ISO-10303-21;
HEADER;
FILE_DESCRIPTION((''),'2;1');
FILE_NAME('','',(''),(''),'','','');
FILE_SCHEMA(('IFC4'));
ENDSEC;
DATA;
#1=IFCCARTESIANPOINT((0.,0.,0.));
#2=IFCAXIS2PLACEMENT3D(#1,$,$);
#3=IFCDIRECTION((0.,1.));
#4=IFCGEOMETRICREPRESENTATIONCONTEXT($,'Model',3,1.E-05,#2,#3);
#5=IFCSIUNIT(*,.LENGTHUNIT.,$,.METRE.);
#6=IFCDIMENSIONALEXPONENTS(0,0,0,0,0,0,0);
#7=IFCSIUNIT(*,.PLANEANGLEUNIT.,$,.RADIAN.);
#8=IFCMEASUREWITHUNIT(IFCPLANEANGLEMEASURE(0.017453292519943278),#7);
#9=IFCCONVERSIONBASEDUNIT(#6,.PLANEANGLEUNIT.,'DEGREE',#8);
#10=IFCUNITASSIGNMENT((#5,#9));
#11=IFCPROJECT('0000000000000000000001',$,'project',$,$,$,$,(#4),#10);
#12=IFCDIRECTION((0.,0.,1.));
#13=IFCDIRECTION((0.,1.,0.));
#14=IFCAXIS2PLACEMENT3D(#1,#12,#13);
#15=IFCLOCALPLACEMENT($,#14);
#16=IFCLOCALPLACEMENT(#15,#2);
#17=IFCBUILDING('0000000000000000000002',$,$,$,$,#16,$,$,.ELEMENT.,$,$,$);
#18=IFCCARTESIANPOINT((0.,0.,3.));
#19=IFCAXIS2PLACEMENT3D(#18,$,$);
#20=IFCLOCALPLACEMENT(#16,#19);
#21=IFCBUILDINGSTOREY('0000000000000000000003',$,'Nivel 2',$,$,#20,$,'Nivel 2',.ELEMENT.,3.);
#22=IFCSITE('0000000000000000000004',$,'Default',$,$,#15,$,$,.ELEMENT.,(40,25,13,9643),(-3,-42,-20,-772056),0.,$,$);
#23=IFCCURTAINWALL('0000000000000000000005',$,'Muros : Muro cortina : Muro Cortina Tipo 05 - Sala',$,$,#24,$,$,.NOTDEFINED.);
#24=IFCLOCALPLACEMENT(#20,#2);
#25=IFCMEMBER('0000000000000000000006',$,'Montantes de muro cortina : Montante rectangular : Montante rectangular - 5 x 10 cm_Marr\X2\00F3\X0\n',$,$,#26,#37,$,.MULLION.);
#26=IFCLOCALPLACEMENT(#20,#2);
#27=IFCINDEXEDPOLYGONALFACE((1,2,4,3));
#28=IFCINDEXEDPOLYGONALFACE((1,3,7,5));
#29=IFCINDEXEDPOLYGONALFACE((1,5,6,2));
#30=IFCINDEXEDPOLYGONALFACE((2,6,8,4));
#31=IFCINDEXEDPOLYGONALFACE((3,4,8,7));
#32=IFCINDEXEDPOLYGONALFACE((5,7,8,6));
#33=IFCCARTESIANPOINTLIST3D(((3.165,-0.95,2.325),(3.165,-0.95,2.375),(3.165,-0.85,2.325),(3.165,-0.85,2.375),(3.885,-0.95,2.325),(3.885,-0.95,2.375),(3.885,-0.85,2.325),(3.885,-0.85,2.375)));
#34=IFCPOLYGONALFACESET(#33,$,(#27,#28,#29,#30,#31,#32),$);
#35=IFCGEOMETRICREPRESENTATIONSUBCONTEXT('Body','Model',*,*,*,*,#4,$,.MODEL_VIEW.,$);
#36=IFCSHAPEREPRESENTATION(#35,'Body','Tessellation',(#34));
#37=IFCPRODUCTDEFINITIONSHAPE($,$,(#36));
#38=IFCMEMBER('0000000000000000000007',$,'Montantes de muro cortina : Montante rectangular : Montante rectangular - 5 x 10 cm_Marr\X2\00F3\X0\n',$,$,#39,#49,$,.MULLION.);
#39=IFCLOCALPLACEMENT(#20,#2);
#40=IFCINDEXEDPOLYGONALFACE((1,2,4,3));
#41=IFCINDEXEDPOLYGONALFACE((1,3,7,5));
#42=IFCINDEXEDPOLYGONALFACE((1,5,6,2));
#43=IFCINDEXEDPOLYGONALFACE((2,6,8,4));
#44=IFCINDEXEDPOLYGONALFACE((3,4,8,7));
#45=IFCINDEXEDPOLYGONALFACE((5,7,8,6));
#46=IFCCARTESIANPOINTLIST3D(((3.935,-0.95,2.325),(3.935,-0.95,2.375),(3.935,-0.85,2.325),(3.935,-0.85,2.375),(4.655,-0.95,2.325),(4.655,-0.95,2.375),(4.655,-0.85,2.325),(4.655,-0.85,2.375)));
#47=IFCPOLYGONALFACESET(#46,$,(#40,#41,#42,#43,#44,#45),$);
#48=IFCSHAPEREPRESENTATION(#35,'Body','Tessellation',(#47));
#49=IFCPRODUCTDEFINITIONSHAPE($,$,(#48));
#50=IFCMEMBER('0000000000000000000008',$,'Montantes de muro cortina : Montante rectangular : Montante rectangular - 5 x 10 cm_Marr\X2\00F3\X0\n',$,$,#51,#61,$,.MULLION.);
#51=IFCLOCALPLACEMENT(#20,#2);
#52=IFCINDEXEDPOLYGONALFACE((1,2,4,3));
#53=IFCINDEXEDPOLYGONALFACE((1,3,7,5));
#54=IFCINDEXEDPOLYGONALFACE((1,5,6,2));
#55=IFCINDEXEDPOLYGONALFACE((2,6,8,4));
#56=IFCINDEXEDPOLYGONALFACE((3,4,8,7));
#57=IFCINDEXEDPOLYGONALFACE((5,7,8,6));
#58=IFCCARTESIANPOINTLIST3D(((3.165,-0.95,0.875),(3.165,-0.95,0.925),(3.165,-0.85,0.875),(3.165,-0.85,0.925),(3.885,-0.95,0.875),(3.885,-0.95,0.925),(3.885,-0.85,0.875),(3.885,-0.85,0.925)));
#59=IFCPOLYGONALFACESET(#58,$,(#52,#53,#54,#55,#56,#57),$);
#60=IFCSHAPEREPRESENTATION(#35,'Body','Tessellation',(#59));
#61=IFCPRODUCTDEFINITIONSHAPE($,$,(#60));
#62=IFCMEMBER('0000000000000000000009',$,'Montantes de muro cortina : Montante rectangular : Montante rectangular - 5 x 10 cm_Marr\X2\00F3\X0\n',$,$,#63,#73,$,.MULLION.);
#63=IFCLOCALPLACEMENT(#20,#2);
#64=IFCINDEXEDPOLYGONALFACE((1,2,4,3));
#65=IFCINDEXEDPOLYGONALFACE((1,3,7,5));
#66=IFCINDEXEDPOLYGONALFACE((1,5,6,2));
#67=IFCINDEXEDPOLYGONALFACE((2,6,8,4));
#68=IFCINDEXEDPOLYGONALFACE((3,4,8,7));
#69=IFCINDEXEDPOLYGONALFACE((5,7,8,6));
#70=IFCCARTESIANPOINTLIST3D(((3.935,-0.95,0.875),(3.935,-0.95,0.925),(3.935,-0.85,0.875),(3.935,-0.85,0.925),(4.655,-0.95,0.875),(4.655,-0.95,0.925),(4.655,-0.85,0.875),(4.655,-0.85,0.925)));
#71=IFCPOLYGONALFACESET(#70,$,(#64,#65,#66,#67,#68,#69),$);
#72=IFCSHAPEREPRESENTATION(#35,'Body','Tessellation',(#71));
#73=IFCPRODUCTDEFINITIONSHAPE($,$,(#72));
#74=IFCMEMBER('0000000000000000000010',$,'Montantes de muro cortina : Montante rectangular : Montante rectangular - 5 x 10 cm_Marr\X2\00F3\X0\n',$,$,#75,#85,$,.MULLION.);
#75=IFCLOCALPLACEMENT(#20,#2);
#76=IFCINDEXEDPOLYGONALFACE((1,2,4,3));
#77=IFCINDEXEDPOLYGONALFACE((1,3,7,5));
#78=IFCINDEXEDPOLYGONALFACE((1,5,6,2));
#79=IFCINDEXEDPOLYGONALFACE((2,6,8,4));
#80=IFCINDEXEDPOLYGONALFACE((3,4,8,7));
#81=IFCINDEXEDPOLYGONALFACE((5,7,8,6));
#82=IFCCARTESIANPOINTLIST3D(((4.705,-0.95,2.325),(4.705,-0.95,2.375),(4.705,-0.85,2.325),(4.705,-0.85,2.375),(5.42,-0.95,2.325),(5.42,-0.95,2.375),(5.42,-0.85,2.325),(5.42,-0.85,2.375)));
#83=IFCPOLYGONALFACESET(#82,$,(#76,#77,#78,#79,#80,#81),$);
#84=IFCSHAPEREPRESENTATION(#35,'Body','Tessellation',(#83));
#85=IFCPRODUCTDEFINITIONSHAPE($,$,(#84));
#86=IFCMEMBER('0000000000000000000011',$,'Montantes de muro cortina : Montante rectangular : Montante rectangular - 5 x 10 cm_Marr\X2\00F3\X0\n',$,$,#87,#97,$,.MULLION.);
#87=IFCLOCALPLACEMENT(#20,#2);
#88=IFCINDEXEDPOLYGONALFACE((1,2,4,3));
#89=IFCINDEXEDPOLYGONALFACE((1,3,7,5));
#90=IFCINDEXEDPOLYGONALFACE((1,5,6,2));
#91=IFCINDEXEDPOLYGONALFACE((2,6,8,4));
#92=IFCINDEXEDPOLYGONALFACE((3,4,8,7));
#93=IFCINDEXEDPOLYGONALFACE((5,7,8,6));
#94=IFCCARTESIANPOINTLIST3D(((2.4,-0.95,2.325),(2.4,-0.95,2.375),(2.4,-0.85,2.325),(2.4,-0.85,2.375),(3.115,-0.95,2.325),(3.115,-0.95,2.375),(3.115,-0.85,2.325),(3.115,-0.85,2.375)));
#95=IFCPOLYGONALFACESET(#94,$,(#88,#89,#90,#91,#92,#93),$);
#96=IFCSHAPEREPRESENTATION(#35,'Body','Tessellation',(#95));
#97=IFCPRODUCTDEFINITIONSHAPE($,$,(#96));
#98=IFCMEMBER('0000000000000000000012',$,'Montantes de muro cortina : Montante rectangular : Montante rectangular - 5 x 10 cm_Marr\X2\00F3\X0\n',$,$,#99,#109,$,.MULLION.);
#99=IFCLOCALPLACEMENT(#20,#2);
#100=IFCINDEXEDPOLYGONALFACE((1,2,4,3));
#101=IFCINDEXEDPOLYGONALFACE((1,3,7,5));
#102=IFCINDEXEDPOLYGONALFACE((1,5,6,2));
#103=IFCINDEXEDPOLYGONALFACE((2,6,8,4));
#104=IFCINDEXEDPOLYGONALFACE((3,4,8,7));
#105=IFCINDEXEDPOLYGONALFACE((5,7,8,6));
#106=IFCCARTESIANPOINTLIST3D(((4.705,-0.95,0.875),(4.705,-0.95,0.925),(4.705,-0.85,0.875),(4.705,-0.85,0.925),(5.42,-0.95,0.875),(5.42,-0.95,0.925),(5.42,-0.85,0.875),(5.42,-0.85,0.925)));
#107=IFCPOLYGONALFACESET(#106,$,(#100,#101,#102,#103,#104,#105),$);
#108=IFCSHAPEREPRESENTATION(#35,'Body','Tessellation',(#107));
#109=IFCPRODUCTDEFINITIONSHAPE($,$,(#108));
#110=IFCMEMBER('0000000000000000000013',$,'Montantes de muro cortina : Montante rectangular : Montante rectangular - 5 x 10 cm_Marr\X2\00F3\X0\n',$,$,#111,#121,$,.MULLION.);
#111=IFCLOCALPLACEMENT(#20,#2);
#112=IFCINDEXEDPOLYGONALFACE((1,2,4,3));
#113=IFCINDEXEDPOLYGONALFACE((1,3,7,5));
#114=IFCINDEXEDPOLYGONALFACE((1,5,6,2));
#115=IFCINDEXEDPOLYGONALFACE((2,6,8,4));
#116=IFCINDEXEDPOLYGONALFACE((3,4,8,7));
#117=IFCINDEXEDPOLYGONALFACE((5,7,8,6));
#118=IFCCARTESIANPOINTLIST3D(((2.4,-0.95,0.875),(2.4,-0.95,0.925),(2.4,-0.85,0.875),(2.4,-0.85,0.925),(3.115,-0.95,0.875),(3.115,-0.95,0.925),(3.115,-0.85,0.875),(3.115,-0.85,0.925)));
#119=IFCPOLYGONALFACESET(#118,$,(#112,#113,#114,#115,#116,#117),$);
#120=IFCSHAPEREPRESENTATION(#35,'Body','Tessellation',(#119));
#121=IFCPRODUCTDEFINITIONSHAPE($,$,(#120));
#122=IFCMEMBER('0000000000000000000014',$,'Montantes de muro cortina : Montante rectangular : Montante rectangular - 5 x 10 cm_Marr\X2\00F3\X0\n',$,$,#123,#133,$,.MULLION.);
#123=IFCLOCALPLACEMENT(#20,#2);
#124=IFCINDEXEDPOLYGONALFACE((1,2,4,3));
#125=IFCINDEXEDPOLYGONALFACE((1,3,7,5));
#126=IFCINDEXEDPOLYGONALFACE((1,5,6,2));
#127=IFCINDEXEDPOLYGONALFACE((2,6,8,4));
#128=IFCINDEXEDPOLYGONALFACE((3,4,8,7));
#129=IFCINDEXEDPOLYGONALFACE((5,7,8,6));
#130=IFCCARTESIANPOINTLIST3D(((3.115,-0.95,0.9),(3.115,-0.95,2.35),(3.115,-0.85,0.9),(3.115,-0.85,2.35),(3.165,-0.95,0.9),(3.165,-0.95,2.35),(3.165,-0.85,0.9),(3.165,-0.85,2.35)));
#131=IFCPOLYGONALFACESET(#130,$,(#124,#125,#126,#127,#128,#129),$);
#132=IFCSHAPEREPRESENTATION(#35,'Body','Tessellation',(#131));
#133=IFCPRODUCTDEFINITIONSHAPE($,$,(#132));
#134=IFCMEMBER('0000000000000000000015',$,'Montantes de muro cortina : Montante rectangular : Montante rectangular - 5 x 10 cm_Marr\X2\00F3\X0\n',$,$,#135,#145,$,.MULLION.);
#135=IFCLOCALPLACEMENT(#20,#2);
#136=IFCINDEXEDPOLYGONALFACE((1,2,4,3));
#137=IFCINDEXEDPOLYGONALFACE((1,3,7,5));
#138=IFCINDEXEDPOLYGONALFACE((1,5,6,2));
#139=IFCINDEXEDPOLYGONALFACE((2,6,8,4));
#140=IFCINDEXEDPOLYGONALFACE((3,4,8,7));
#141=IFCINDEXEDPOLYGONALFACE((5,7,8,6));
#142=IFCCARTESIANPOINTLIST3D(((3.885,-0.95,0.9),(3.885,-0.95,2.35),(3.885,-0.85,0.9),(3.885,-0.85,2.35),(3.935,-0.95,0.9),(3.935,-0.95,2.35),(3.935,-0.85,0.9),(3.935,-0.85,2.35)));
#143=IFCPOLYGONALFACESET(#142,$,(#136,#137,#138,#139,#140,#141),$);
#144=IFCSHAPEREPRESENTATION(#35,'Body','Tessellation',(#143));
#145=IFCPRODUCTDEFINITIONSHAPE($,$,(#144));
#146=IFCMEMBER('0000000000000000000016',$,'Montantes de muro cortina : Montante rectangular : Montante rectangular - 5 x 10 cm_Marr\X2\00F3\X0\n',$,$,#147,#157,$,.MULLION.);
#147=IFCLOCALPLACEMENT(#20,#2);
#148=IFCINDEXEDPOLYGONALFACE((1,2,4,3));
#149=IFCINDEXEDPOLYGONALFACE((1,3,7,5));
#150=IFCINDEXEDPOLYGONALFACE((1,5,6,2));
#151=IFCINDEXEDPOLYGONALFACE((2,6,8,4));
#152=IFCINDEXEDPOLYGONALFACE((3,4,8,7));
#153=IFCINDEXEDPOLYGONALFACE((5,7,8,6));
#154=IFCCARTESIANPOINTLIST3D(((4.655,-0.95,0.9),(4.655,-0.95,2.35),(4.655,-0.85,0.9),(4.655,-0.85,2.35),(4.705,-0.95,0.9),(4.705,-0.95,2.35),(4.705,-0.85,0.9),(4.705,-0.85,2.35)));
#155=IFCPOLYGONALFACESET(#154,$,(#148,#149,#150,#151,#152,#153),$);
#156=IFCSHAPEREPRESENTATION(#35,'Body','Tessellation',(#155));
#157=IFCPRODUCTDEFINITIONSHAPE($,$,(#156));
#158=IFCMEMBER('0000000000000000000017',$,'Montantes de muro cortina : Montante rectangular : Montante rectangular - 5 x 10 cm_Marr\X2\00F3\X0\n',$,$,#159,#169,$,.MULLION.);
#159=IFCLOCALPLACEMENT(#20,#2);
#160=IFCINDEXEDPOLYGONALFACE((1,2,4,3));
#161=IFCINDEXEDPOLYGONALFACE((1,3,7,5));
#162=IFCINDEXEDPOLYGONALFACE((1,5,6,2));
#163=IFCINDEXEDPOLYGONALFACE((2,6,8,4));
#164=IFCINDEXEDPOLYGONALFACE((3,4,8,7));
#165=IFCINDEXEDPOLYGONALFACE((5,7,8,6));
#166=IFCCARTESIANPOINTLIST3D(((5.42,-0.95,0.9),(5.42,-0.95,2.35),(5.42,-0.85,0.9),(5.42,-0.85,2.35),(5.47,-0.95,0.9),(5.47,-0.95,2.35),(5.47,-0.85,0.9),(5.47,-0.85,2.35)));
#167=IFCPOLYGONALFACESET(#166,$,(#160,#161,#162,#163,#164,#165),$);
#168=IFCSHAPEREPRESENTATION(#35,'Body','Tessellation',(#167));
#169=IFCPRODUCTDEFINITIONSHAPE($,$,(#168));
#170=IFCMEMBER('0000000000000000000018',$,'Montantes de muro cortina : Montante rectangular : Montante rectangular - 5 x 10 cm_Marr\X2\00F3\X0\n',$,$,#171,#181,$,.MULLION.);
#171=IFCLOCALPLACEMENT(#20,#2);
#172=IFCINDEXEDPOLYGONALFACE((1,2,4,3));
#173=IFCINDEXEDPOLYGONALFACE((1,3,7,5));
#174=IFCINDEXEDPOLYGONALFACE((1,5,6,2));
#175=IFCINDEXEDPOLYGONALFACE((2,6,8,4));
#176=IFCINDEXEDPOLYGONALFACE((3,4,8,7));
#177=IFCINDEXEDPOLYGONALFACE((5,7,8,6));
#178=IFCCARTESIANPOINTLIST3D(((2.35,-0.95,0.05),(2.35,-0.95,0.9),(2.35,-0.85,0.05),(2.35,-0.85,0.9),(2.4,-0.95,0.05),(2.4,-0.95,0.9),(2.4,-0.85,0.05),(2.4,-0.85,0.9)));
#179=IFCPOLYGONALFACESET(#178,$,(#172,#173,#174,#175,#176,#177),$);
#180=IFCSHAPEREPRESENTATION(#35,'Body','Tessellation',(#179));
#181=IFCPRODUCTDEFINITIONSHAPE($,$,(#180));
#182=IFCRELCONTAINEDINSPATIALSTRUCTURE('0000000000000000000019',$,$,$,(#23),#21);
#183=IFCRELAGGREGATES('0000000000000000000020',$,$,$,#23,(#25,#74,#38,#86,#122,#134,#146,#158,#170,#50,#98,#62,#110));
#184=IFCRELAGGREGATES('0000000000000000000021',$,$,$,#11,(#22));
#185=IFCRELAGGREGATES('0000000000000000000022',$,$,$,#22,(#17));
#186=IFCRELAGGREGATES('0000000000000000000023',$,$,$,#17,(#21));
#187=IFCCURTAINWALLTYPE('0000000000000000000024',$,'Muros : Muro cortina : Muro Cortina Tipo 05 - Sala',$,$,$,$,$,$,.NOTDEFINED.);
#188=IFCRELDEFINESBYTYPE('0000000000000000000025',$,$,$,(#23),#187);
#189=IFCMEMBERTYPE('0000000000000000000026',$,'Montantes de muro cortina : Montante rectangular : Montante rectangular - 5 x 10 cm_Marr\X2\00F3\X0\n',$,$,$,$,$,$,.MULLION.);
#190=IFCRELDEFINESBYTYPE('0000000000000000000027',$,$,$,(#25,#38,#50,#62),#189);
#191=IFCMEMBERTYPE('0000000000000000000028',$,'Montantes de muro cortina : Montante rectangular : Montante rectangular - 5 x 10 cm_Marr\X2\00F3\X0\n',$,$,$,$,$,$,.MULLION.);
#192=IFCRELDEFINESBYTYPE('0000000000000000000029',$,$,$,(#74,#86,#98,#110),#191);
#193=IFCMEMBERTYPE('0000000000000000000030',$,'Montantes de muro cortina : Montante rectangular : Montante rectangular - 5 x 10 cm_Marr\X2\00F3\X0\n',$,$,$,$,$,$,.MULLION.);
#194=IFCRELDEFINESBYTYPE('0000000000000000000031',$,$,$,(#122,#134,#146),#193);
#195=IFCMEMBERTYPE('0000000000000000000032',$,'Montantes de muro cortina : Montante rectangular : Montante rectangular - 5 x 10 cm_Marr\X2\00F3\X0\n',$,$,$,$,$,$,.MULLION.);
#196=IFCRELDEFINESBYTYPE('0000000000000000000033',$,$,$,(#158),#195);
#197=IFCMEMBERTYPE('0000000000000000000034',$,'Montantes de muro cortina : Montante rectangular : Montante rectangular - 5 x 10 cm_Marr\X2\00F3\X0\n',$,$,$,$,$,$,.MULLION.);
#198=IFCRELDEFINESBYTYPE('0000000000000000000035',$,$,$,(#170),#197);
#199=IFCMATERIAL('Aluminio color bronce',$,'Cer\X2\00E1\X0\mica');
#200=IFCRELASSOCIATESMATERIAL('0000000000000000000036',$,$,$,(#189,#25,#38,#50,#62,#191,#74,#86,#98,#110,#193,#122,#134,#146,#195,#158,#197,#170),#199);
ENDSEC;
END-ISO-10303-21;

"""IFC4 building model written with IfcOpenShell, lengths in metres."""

from ifc_helpers import new_model, entity, si_unit, converted_unit, direction, frame, origin, place, context, subcontext, project, spatial, indexed_curve, outline, extrude, source, transform, mapped, material, type_object, type_shapes, element, aggregate, save


model = new_model("IFC4")

# Units and contexts
model_context = context("Model", 3, precision=1e-05, world=origin(), true_north=direction((0.0, 1.0)))
body_context = subcontext(model_context, "Body", "Model", "MODEL_VIEW")
ifc_project = project(units=[si_unit("LENGTHUNIT", "METRE"), converted_unit("PLANEANGLEUNIT", "DEGREE", entity("IfcPlaneAngleMeasure", 0.017453292519943278), si_unit("PLANEANGLEUNIT", "RADIAN"), dimensions=[0, 0, 0, 0, 0, 0, 0])], contexts=[model_context])

# Site, building, storey
site_placement = place(None, frame((0.0, 0.0, 0.0), z_axis=(0.0, 0.0, 1.0), x_axis=(0.0, 1.0, 0.0)))
site = spatial("IfcSite", under=ifc_project, at=site_placement, Name="Default", CompositionType="ELEMENT", RefLatitude=(40, 25, 13, 9643), RefLongitude=(-3, -42, -20, -772056), RefElevation=0.0)
building_placement = place(site_placement, origin())
building = spatial("IfcBuilding", under=site, at=building_placement, CompositionType="ELEMENT")
storey_placement = place(building_placement, frame((0.0, 0.0, 3.0)))
storey = spatial("IfcBuildingStorey", under=building, at=storey_placement, Name="Nivel 2", LongName="Nivel 2", CompositionType="ELEMENT", Elevation=3.0)

# Curtain wall, members
curtain_wall_type = type_object("IfcCurtainWallType", Name="Muros : Muro cortina : Muro Cortina Tipo 05 - Sala", PredefinedType="NOTDEFINED")
curtain_wall_placement = place(storey_placement, frame((0.0, 0.0, -3.0)))
curtain_wall = element("IfcCurtainWall", 1, at=curtain_wall_placement, inside=storey, type_object=curtain_wall_type, Name="Muros : Muro cortina : Muro Cortina Tipo 05 - Sala", PredefinedType="NOTDEFINED")
ifc_material_1 = material(Name="Aluminio color bronce", Category="Cerámica")
member_type_1 = type_object("IfcMemberType", Name="Montantes de muro cortina : Montante rectangular : Montante rectangular - 5 x 10 cm_Marrón", PredefinedType="MULLION", material=ifc_material_1)
shared_shape_1 = source(origin(), body_context, "Body", "SweptSolid", [
    extrude(outline(indexed_curve([(-0.05, -0.025), (0.05, -0.025), (0.05, 0.025), (-0.05, 0.025), (-0.05, -0.025)], self_intersect=False)), frame((0.0, 0.0, -0.72), z_axis=(0.0, 0.0, 1.0), x_axis=(0.0, 1.0, 0.0)), (0.0, 0.0, 1.0), 0.72),
])
type_shapes(member_type_1, [shared_shape_1])
member_1_placement = place(curtain_wall_placement, frame((3.885, -0.9, 5.35), z_axis=(1.0, 0.0, 0.0), x_axis=(0.0, 0.0, 1.0)))
member_1 = element("IfcMember", 2, at=member_1_placement, type_object=member_type_1, material=ifc_material_1, Name="Montantes de muro cortina : Montante rectangular : Montante rectangular - 5 x 10 cm_Marrón", PredefinedType="MULLION", context=body_context, shape_type="MappedRepresentation", body=[
    mapped(shared_shape_1, transform((0.0, 0.0, 0.0), scale=1.0)),
])
member_2_placement = place(curtain_wall_placement, frame((4.655, -0.9, 5.35), z_axis=(1.0, 0.0, 0.0), x_axis=(0.0, 0.0, 1.0)))
member_2 = element("IfcMember", 3, at=member_2_placement, type_object=member_type_1, material=ifc_material_1, Name="Montantes de muro cortina : Montante rectangular : Montante rectangular - 5 x 10 cm_Marrón", PredefinedType="MULLION", context=body_context, shape_type="MappedRepresentation", body=[
    mapped(shared_shape_1, transform((0.0, 0.0, 0.0), scale=1.0)),
])
member_3_placement = place(curtain_wall_placement, frame((3.885, -0.9, 3.9), z_axis=(1.0, 0.0, 0.0), x_axis=(0.0, 0.0, 1.0)))
member_3 = element("IfcMember", 4, at=member_3_placement, type_object=member_type_1, material=ifc_material_1, Name="Montantes de muro cortina : Montante rectangular : Montante rectangular - 5 x 10 cm_Marrón", PredefinedType="MULLION", context=body_context, shape_type="MappedRepresentation", body=[
    mapped(shared_shape_1, transform((0.0, 0.0, 0.0), scale=1.0)),
])
member_4_placement = place(curtain_wall_placement, frame((4.655, -0.9, 3.9), z_axis=(1.0, 0.0, 0.0), x_axis=(0.0, 0.0, 1.0)))
member_4 = element("IfcMember", 5, at=member_4_placement, type_object=member_type_1, material=ifc_material_1, Name="Montantes de muro cortina : Montante rectangular : Montante rectangular - 5 x 10 cm_Marrón", PredefinedType="MULLION", context=body_context, shape_type="MappedRepresentation", body=[
    mapped(shared_shape_1, transform((0.0, 0.0, 0.0), scale=1.0)),
])
member_type_2 = type_object("IfcMemberType", Name="Montantes de muro cortina : Montante rectangular : Montante rectangular - 5 x 10 cm_Marrón", PredefinedType="MULLION", material=ifc_material_1)
shared_shape_2 = source(origin(), body_context, "Body", "SweptSolid", [
    extrude(outline(indexed_curve([(-0.05, -0.025), (0.05, -0.025), (0.05, 0.025), (-0.05, 0.025), (-0.05, -0.025)], self_intersect=False)), frame((0.0, 0.0, -0.715), z_axis=(0.0, 0.0, 1.0), x_axis=(0.0, 1.0, 0.0)), (0.0, 0.0, 1.0), 0.715),
])
type_shapes(member_type_2, [shared_shape_2])
member_5_placement = place(curtain_wall_placement, frame((5.42, -0.9, 5.35), z_axis=(1.0, 0.0, 0.0), x_axis=(0.0, 0.0, 1.0)))
member_5 = element("IfcMember", 6, at=member_5_placement, type_object=member_type_2, material=ifc_material_1, Name="Montantes de muro cortina : Montante rectangular : Montante rectangular - 5 x 10 cm_Marrón", PredefinedType="MULLION", context=body_context, shape_type="MappedRepresentation", body=[
    mapped(shared_shape_2, transform((0.0, 0.0, 0.0), scale=1.0)),
])
member_6_placement = place(curtain_wall_placement, frame((3.115, -0.9, 5.35), z_axis=(1.0, 0.0, 0.0), x_axis=(0.0, 0.0, 1.0)))
member_6 = element("IfcMember", 7, at=member_6_placement, type_object=member_type_2, material=ifc_material_1, Name="Montantes de muro cortina : Montante rectangular : Montante rectangular - 5 x 10 cm_Marrón", PredefinedType="MULLION", context=body_context, shape_type="MappedRepresentation", body=[
    mapped(shared_shape_2, transform((0.0, 0.0, 0.0), scale=1.0)),
])
member_7_placement = place(curtain_wall_placement, frame((5.42, -0.9, 3.9), z_axis=(1.0, 0.0, 0.0), x_axis=(0.0, 0.0, 1.0)))
member_7 = element("IfcMember", 8, at=member_7_placement, type_object=member_type_2, material=ifc_material_1, Name="Montantes de muro cortina : Montante rectangular : Montante rectangular - 5 x 10 cm_Marrón", PredefinedType="MULLION", context=body_context, shape_type="MappedRepresentation", body=[
    mapped(shared_shape_2, transform((0.0, 0.0, 0.0), scale=1.0)),
])
member_8_placement = place(curtain_wall_placement, frame((3.115, -0.9, 3.9), z_axis=(1.0, 0.0, 0.0), x_axis=(0.0, 0.0, 1.0)))
member_8 = element("IfcMember", 9, at=member_8_placement, type_object=member_type_2, material=ifc_material_1, Name="Montantes de muro cortina : Montante rectangular : Montante rectangular - 5 x 10 cm_Marrón", PredefinedType="MULLION", context=body_context, shape_type="MappedRepresentation", body=[
    mapped(shared_shape_2, transform((0.0, 0.0, 0.0), scale=1.0)),
])
member_type_3 = type_object("IfcMemberType", Name="Montantes de muro cortina : Montante rectangular : Montante rectangular - 5 x 10 cm_Marrón", PredefinedType="MULLION", material=ifc_material_1)
shared_shape_3 = source(origin(), body_context, "Body", "SweptSolid", [
    extrude(outline(indexed_curve([(-0.05, -0.025), (0.05, -0.025), (0.05, 0.025), (-0.05, 0.025), (-0.05, -0.025)], self_intersect=False)), frame((0.0, 0.0, -1.45), z_axis=(0.0, 0.0, 1.0), x_axis=(0.0, 1.0, 0.0)), (0.0, 0.0, 1.0), 1.45),
])
type_shapes(member_type_3, [shared_shape_3])
member_9_placement = place(curtain_wall_placement, frame((3.14, -0.9, 3.9), z_axis=(0.0, 0.0, -1.0), x_axis=(1.0, 0.0, 0.0)))
member_9 = element("IfcMember", 10, at=member_9_placement, type_object=member_type_3, material=ifc_material_1, Name="Montantes de muro cortina : Montante rectangular : Montante rectangular - 5 x 10 cm_Marrón", PredefinedType="MULLION", context=body_context, shape_type="MappedRepresentation", body=[
    mapped(shared_shape_3, transform((0.0, 0.0, 0.0), scale=1.0)),
])
member_10_placement = place(curtain_wall_placement, frame((3.91, -0.9, 3.9), z_axis=(0.0, 0.0, -1.0), x_axis=(1.0, 0.0, 0.0)))
member_10 = element("IfcMember", 11, at=member_10_placement, type_object=member_type_3, material=ifc_material_1, Name="Montantes de muro cortina : Montante rectangular : Montante rectangular - 5 x 10 cm_Marrón", PredefinedType="MULLION", context=body_context, shape_type="MappedRepresentation", body=[
    mapped(shared_shape_3, transform((0.0, 0.0, 0.0), scale=1.0)),
])
member_11_placement = place(curtain_wall_placement, frame((4.68, -0.9, 3.9), z_axis=(0.0, 0.0, -1.0), x_axis=(1.0, 0.0, 0.0)))
member_11 = element("IfcMember", 12, at=member_11_placement, type_object=member_type_3, material=ifc_material_1, Name="Montantes de muro cortina : Montante rectangular : Montante rectangular - 5 x 10 cm_Marrón", PredefinedType="MULLION", context=body_context, shape_type="MappedRepresentation", body=[
    mapped(shared_shape_3, transform((0.0, 0.0, 0.0), scale=1.0)),
])
member_type_4 = type_object("IfcMemberType", Name="Montantes de muro cortina : Montante rectangular : Montante rectangular - 5 x 10 cm_Marrón", PredefinedType="MULLION", material=ifc_material_1)
shared_shape_4 = source(origin(), body_context, "Body", "SweptSolid", [
    extrude(outline(indexed_curve([(-0.05, -0.025), (0.05, -0.025), (0.05, 0.025), (-0.05, 0.025), (-0.05, -0.025)], self_intersect=False)), frame((-0.025, 0.0, -1.45), z_axis=(0.0, 0.0, 1.0), x_axis=(0.0, 1.0, 0.0)), (0.0, 0.0, 1.0), 1.45),
])
type_shapes(member_type_4, [shared_shape_4])
member_12_placement = place(curtain_wall_placement, frame((5.47, -0.9, 3.9), z_axis=(0.0, 0.0, -1.0), x_axis=(1.0, 0.0, 0.0)))
member_12 = element("IfcMember", 13, at=member_12_placement, type_object=member_type_4, material=ifc_material_1, Name="Montantes de muro cortina : Montante rectangular : Montante rectangular - 5 x 10 cm_Marrón", PredefinedType="MULLION", context=body_context, shape_type="MappedRepresentation", body=[
    mapped(shared_shape_4, transform((0.0, 0.0, 0.0), scale=1.0)),
])
member_type_5 = type_object("IfcMemberType", Name="Montantes de muro cortina : Montante rectangular : Montante rectangular - 5 x 10 cm_Marrón", PredefinedType="MULLION", material=ifc_material_1)
shared_shape_5 = source(origin(), body_context, "Body", "SweptSolid", [
    extrude(outline(indexed_curve([(-0.025, -0.05), (0.025, -0.05), (0.025, 0.05), (-0.025, 0.05), (-0.025, -0.05)], self_intersect=False)), frame((-0.025, 0.0, -0.85)), (0.0, 0.0, 1.0), 0.85),
])
type_shapes(member_type_5, [shared_shape_5])
member_13_placement = place(curtain_wall_placement, frame((2.35, -0.9, 3.9), z_axis=(0.0, 0.0, 1.0), x_axis=(-1.0, 0.0, 0.0)))
member_13 = element("IfcMember", 14, at=member_13_placement, type_object=member_type_5, material=ifc_material_1, Name="Montantes de muro cortina : Montante rectangular : Montante rectangular - 5 x 10 cm_Marrón", PredefinedType="MULLION", context=body_context, shape_type="MappedRepresentation", body=[
    mapped(shared_shape_5, transform((0.0, 0.0, 0.0), scale=1.0)),
])
aggregate(curtain_wall, [member_1, member_5, member_2, member_6, member_9, member_10, member_11, member_12, member_13, member_3, member_7, member_4, member_8])

save(model, "model.ifc")
